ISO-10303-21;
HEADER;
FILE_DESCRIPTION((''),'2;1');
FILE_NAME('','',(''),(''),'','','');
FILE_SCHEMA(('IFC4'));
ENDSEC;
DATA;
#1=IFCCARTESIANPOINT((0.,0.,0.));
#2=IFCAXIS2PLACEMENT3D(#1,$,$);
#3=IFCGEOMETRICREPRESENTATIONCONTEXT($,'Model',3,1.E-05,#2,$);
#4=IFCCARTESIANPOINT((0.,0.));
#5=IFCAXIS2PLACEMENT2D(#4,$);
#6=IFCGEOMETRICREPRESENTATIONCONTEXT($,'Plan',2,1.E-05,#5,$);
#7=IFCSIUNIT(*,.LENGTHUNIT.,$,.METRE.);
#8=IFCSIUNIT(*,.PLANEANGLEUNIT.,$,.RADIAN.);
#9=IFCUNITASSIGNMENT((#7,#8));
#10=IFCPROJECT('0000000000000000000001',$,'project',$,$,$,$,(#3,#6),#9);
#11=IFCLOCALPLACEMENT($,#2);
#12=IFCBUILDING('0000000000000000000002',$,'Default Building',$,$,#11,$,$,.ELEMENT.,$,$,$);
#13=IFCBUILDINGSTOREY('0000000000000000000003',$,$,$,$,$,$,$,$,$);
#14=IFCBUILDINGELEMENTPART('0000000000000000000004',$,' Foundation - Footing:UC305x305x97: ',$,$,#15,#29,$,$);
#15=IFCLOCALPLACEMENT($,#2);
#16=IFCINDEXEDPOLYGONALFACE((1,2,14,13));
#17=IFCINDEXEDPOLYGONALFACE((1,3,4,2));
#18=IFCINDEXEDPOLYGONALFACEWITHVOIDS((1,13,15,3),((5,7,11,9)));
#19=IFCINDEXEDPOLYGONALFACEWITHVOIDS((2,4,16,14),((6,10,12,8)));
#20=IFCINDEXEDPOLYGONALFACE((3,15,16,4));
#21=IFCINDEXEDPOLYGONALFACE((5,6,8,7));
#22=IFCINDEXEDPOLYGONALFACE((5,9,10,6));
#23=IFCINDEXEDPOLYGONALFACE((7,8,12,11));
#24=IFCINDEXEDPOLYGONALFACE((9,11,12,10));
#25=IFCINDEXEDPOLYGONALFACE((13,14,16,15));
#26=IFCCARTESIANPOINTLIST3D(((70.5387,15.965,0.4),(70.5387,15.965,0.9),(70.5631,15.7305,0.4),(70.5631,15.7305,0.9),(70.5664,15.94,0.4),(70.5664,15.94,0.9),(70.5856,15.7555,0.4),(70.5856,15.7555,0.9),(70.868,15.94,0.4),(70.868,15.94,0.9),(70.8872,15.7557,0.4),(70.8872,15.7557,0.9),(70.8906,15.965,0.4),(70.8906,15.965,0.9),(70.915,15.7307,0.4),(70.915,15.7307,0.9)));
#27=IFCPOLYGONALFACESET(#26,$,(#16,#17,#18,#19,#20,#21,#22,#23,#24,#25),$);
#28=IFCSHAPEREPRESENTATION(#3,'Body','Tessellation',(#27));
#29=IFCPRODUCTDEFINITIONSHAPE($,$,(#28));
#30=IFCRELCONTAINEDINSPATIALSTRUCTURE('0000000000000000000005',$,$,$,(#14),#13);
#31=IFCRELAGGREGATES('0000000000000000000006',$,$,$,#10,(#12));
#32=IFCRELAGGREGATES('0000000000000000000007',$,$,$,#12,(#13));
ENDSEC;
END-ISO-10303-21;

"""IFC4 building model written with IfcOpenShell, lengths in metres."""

from ifc_helpers import new_model, si_unit, origin, origin_2d, place, context, project, spatial, polyline, outline, extrude, element, save


model = new_model("IFC4")

# Units and contexts
model_context = context("Model", 3, precision=1e-05, world=origin())
plan_context = context("Plan", 2, precision=1e-05, world=origin_2d())
ifc_project = project(units=[si_unit("LENGTHUNIT", "METRE"), si_unit("PLANEANGLEUNIT", "RADIAN")], contexts=[model_context, plan_context])

# Building, storey
building_placement = place(None, origin())
building = spatial("IfcBuilding", under=ifc_project, at=building_placement, Name="Default Building", CompositionType="ELEMENT")
storey = spatial("IfcBuildingStorey", under=building)

# Building element part, opening
building_element_part_1 = element("IfcBuildingElementPart", 1, inside=storey, Name=" Foundation - Footing:UC305x305x97: ", context=model_context, shape_type="SweptSolid", body=[
    extrude(outline(polyline([(70.915, 15.7307, 0.4), (70.8906, 15.965, 0.4), (70.5387, 15.965, 0.4), (70.5631, 15.7305, 0.4), (70.915, 15.7307, 0.4)])), None, (0.0, 0.0, 1.0), 0.5),
])
element("IfcOpeningElement", 2, inside=storey, cuts=building_element_part_1, context=model_context, shape_type="SweptSolid", body=[
    extrude(outline(polyline([(70.8872, 15.7557, 0.4), (70.868, 15.94, 0.4), (70.5664, 15.94, 0.4), (70.5856, 15.7555, 0.4), (70.8872, 15.7557, 0.4)])), None, (0.0, 0.0, 1.0), 0.5),
])

save(model, "model.ifc")
